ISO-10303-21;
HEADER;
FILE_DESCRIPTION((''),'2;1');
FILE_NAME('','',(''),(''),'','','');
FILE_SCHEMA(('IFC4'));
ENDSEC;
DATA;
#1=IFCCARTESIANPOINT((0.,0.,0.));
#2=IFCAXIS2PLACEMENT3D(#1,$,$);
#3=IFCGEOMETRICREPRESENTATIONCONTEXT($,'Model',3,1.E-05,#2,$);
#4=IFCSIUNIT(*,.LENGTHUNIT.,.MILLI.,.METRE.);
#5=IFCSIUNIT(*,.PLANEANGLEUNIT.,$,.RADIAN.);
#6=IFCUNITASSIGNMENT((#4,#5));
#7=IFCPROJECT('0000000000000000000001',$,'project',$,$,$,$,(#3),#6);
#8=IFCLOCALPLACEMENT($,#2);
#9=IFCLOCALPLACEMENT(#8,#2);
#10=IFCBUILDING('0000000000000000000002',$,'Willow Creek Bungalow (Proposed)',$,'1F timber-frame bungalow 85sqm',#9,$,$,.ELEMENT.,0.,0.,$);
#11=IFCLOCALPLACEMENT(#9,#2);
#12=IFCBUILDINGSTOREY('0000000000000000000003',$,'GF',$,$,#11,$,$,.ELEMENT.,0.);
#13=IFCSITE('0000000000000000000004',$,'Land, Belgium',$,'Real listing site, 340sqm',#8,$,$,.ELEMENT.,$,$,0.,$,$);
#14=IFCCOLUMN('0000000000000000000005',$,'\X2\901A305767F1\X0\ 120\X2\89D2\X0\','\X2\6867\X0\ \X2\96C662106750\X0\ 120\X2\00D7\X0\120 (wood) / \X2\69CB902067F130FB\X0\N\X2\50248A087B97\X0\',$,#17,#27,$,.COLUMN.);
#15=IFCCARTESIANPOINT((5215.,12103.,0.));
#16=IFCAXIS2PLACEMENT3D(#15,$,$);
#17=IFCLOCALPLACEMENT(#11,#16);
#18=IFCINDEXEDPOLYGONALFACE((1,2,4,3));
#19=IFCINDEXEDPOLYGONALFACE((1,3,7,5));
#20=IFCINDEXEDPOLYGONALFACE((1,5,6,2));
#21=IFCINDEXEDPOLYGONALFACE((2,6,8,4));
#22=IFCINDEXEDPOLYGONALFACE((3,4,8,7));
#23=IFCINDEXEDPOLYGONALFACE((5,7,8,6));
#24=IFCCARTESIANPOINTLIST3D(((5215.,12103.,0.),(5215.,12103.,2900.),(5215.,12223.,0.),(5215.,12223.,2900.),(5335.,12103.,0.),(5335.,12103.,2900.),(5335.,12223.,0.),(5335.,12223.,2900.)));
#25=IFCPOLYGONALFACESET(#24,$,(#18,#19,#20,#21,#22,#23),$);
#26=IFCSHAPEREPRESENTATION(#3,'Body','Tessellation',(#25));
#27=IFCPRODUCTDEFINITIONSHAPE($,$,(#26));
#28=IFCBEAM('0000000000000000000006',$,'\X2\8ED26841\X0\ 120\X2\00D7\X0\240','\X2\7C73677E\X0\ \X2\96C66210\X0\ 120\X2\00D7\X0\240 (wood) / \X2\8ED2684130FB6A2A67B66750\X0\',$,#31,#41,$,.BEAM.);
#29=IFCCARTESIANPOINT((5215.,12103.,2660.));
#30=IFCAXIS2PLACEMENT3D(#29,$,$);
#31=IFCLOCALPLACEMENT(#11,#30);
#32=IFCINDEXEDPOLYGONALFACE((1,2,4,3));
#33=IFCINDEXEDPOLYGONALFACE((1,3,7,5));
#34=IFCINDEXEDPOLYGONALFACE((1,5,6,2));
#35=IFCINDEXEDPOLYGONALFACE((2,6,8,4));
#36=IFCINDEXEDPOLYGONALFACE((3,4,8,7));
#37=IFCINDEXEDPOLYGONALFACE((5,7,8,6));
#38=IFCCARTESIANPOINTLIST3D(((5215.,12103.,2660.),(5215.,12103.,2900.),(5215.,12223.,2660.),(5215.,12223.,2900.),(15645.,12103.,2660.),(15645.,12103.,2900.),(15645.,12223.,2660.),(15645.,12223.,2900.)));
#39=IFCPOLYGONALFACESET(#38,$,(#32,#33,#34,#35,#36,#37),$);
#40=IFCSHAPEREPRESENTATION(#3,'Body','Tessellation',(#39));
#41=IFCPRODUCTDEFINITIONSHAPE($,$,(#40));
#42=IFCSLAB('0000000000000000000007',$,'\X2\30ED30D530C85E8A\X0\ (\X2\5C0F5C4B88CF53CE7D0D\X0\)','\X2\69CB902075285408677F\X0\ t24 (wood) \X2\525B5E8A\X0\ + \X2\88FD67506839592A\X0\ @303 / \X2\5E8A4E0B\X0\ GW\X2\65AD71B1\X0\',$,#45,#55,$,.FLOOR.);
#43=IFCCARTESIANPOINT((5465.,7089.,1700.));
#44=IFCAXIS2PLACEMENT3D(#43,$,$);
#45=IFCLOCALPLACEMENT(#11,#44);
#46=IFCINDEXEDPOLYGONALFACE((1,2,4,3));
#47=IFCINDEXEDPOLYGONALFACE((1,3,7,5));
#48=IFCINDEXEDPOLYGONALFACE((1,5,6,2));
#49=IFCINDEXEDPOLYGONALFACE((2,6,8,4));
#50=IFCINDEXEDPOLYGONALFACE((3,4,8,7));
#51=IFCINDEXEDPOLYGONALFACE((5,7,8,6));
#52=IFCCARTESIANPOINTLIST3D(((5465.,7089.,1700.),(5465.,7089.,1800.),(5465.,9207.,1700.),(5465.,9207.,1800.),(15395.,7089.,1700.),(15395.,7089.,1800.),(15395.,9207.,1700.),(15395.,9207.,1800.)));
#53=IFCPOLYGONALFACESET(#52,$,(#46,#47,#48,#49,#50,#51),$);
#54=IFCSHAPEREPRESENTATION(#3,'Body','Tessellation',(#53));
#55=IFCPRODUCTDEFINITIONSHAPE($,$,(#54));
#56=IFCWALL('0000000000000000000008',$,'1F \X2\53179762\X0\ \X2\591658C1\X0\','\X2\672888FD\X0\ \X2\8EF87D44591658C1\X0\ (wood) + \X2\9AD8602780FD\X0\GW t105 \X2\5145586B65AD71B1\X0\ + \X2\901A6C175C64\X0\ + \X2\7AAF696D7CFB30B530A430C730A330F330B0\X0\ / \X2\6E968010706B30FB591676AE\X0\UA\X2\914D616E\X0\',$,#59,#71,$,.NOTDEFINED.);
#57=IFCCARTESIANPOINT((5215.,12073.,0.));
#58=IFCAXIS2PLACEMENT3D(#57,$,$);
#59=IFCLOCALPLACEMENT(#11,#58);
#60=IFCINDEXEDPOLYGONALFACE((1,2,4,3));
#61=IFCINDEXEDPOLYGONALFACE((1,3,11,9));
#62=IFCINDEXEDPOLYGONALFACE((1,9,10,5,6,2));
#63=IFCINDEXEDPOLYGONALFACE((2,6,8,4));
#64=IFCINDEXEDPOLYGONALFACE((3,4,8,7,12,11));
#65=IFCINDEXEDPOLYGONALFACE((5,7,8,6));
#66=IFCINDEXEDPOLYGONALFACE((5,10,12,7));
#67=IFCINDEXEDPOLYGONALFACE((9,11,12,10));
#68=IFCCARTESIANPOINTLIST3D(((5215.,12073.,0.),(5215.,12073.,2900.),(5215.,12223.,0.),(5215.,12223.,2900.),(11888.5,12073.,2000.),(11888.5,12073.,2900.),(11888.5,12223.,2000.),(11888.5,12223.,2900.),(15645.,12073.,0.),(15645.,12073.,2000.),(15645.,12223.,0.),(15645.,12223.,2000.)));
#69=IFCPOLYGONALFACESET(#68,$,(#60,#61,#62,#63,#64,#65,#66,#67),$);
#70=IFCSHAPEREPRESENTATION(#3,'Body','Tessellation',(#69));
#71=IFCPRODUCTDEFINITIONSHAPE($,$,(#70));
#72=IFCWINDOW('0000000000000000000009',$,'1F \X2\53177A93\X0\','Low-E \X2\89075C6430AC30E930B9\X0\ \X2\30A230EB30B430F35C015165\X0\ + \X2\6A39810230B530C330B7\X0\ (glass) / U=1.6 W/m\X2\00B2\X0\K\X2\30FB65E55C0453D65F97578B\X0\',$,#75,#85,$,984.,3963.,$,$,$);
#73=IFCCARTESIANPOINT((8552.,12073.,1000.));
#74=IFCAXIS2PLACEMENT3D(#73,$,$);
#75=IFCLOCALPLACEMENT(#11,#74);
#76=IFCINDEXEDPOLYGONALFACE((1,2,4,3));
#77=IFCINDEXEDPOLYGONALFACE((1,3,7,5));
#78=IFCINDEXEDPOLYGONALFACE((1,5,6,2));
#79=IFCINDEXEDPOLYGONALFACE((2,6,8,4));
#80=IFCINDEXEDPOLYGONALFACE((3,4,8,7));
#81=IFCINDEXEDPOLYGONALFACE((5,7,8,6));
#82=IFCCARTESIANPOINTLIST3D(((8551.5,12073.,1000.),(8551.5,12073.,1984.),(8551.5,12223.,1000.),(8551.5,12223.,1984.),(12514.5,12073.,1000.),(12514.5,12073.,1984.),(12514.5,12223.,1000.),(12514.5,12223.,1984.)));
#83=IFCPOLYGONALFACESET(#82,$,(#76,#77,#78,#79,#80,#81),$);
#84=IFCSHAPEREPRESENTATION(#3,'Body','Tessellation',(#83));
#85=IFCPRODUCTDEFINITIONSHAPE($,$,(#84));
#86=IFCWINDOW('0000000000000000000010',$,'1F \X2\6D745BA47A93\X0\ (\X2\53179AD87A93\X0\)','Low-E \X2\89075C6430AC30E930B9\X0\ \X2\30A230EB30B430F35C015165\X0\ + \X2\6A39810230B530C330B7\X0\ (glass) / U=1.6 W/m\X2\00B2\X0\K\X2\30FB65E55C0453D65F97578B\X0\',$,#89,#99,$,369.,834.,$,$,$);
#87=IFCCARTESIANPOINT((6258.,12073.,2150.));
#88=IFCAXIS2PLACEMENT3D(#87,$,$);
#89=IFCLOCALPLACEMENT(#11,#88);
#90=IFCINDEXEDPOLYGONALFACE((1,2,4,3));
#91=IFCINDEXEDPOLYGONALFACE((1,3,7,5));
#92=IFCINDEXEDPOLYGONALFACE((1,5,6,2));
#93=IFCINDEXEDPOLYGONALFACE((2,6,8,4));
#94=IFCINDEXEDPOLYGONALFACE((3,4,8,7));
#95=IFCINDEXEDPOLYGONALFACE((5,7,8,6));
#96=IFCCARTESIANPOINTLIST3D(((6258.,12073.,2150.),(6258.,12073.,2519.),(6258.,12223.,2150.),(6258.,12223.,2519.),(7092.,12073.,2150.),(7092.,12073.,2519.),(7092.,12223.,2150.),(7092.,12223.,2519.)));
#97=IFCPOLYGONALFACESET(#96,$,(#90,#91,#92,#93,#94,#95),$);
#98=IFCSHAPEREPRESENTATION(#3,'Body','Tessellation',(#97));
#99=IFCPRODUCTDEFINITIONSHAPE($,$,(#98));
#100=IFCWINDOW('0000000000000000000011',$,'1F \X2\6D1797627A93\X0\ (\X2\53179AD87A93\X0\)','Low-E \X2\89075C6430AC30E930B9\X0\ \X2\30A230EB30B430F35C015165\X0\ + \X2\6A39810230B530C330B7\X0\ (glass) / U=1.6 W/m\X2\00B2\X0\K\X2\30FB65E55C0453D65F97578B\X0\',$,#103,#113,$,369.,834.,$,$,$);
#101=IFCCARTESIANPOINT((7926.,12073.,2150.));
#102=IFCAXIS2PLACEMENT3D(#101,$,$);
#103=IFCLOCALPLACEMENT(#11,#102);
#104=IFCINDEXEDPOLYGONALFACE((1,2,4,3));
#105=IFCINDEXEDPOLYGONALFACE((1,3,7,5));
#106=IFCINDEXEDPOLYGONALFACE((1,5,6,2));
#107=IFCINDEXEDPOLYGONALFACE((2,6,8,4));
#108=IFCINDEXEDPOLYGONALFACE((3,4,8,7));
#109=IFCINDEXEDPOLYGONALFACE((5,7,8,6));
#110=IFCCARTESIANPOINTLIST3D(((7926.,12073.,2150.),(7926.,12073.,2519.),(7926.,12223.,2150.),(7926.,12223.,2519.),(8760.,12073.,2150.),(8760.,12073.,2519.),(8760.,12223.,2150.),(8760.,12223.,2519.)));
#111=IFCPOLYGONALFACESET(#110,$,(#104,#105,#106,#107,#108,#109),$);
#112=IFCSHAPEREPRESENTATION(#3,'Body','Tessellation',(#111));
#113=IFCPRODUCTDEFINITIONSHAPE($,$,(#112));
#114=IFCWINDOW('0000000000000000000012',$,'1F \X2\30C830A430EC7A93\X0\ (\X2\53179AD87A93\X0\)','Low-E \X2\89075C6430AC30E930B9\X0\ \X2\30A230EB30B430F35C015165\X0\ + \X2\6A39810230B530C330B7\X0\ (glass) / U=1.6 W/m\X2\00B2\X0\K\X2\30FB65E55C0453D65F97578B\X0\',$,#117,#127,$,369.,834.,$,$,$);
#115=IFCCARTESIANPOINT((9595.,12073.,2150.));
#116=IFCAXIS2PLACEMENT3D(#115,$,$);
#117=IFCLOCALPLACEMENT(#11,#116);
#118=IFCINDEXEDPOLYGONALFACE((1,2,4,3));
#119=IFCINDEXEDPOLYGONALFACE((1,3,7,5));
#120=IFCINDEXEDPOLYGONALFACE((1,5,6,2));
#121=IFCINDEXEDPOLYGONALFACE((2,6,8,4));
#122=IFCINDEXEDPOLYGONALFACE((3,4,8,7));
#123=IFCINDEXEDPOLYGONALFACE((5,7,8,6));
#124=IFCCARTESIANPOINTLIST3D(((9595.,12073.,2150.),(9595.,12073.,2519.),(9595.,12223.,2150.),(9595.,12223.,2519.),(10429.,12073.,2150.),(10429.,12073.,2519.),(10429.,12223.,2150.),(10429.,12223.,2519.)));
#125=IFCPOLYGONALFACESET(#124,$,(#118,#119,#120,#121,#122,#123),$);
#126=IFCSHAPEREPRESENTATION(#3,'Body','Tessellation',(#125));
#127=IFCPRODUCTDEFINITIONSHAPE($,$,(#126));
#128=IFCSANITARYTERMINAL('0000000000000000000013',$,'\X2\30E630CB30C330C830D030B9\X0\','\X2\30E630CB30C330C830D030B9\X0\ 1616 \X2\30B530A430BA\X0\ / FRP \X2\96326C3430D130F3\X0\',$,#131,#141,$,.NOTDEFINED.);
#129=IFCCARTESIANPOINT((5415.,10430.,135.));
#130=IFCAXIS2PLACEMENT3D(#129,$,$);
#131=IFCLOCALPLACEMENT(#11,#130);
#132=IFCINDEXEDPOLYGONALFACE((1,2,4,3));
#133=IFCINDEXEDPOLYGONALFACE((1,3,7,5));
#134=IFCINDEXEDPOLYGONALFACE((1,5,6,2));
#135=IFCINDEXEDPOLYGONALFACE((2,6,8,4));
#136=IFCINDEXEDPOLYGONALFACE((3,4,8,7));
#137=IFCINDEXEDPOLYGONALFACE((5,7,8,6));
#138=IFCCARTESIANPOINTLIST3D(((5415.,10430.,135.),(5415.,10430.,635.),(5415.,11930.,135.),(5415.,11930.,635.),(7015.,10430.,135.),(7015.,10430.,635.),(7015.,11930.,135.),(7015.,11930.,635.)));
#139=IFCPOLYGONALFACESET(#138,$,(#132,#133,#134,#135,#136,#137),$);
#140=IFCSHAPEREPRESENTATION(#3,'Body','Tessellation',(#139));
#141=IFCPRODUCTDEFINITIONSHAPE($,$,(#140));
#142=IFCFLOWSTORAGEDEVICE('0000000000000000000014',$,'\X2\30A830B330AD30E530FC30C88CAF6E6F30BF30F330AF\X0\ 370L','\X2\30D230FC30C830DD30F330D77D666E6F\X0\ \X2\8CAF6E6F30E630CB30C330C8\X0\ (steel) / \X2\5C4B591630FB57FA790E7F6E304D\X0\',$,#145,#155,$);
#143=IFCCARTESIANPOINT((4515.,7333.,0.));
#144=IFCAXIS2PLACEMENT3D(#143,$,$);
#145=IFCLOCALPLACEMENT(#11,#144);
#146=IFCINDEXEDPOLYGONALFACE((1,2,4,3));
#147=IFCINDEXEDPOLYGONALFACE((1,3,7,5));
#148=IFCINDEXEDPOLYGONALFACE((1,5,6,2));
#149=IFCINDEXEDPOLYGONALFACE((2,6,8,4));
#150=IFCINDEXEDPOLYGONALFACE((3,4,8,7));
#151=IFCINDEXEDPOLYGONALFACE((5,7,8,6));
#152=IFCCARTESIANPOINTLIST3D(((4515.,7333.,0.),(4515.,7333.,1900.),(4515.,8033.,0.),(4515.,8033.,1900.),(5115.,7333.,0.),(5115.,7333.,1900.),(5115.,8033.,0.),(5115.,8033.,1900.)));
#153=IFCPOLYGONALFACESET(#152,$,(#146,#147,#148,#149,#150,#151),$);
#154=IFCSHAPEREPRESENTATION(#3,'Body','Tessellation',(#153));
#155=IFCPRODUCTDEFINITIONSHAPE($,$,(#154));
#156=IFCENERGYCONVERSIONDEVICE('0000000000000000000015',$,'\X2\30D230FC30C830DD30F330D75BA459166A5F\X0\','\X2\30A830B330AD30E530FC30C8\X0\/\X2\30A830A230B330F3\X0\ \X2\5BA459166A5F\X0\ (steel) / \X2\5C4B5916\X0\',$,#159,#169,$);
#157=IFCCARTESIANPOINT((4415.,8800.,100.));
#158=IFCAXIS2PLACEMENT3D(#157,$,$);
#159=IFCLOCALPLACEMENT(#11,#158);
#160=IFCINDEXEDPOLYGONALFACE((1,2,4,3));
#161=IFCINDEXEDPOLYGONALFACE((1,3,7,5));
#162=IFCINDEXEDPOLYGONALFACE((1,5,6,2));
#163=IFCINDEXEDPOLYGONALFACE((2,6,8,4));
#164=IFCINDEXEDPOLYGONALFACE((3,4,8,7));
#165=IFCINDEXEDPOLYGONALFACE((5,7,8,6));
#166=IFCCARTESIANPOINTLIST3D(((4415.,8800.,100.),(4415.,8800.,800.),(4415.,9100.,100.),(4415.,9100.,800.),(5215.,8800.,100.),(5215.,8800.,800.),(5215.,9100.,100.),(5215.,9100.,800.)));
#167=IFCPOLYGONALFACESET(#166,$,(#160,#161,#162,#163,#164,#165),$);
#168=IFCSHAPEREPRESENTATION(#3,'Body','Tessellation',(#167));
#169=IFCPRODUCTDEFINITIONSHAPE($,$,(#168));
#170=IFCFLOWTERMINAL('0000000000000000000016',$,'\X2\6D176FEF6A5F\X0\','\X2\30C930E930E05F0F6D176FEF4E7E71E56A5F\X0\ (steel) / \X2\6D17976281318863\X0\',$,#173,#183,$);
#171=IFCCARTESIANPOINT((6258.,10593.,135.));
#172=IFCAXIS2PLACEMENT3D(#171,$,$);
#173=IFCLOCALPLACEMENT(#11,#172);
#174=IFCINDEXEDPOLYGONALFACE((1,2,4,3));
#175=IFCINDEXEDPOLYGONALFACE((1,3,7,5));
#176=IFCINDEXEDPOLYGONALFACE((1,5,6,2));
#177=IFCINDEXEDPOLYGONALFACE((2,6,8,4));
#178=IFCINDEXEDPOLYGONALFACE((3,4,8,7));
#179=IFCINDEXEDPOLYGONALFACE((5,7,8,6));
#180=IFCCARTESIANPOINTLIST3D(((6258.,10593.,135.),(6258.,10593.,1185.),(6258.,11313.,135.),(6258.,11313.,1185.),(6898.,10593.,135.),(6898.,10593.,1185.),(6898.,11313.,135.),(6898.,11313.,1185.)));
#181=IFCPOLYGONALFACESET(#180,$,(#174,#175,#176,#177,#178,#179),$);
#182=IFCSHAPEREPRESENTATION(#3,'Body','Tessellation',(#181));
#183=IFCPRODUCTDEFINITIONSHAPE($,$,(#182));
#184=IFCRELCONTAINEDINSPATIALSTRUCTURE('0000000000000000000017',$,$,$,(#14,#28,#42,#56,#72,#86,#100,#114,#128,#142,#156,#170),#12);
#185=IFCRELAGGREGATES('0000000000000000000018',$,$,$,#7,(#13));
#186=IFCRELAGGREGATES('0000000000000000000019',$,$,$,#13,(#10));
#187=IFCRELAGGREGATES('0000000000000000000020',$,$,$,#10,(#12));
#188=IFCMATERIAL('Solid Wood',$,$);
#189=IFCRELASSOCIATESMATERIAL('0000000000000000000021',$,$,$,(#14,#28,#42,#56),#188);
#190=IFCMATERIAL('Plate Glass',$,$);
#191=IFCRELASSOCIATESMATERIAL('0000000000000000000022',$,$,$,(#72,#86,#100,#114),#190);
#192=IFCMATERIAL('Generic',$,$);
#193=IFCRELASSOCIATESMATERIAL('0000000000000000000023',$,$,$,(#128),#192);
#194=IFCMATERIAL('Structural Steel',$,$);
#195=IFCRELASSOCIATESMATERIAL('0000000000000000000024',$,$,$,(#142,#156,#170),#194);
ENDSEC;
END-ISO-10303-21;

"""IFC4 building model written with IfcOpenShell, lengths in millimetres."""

from ifc_helpers import new_model, si_unit, frame, frame_2d, origin, place, context, project, spatial, rectangle, extrude, material, element, fill, save


model = new_model("IFC4")

# Units and contexts
model_context = context("Model", 3, precision=1e-05, world=origin())
ifc_project = project(units=[si_unit("LENGTHUNIT", "METRE", prefix="MILLI"), si_unit("PLANEANGLEUNIT", "RADIAN")], contexts=[model_context])

# Site, building, storey
site_placement = place(None, origin())
site = spatial("IfcSite", under=ifc_project, at=site_placement, Name="Land, Belgium", ObjectType="Real listing site, 340sqm", CompositionType="ELEMENT", RefElevation=0.0)
building_placement = place(site_placement, origin())
building = spatial("IfcBuilding", under=site, at=building_placement, Name="Willow Creek Bungalow (Proposed)", ObjectType="1F timber-frame bungalow 85sqm", CompositionType="ELEMENT", ElevationOfRefHeight=0.0, ElevationOfTerrain=0.0)
storey_placement = place(building_placement, origin())
storey = spatial("IfcBuildingStorey", under=building, at=storey_placement, Name="GF", CompositionType="ELEMENT", Elevation=0.0)

# Column
ifc_material_1 = material(Name="Solid Wood")
column_1_placement = place(storey_placement, frame((5215.0, 12103.0, 0.0)))
element("IfcColumn", 1, at=column_1_placement, inside=storey, material=ifc_material_1, Name="通し柱 120角", Description="桧 集成材 120×120 (wood) / 構造柱・N値計算", PredefinedType="COLUMN", context=model_context, shape_type="SweptSolid", body=[
    extrude(rectangle(XDim=120.0, YDim=120.0, at=frame_2d((60.0, 60.0))), frame((5215.0, 12103.0, 0.0)), (0.0, 0.0, 1.0), 2900.0),
])

# Beam
beam_1_placement = place(storey_placement, frame((5215.0, 12103.0, 2660.0)))
element("IfcBeam", 2, at=beam_1_placement, inside=storey, material=ifc_material_1, Name="軒桁 120×240", Description="米松 集成 120×240 (wood) / 軒桁・横架材", PredefinedType="BEAM", context=model_context, shape_type="SweptSolid", body=[
    extrude(rectangle(XDim=10430.0, YDim=120.0, at=frame_2d((5215.0, 60.0))), frame((5215.0, 12103.0, 2660.0)), (0.0, 0.0, 1.0), 240.0),
])

# Slab
slab_placement = place(storey_placement, frame((5465.0, 7089.0, 1700.0)))
element("IfcSlab", 3, at=slab_placement, inside=storey, material=ifc_material_1, Name="ロフト床 (小屋裏収納)", Description="構造用合板 t24 (wood) 剛床 + 製材根太 @303 / 床下 GW断熱", PredefinedType="FLOOR", context=model_context, shape_type="SweptSolid", body=[
    extrude(rectangle(XDim=9930.0, YDim=2118.0, at=frame_2d((4965.0, 1059.0))), frame((5465.0, 7089.0, 1700.0)), (0.0, 0.0, 1.0), 100.0),
])

# Wall, openings, windows
wall_1_placement = place(storey_placement, frame((5215.0, 12073.0, 0.0)))
wall_1 = element("IfcWall", 4, at=wall_1_placement, inside=storey, material=ifc_material_1, Name="1F 北面 外壁", Description="木製 軸組外壁 (wood) + 高性能GW t105 充填断熱 + 通気層 + 窯業系サイディング / 準耐火・外皮UA配慮", PredefinedType="NOTDEFINED", context=model_context, shape_type="SweptSolid", body=[
    extrude(rectangle(XDim=10430.0, YDim=150.0, at=frame_2d((5215.0, 75.0))), frame((5215.0, 12073.0, 0.0)), (0.0, 0.0, 1.0), 2900.0),
])
opening_1_placement = place(storey_placement, frame((8552.0, 12073.0, 1000.0)))
opening_1 = element("IfcOpeningElement", 5, at=opening_1_placement, cuts=wall_1, PredefinedType="NOTDEFINED", context=model_context, shape_type="SweptSolid", body=[
    extrude(rectangle(XDim=3963.0, YDim=150.0, at=frame_2d((1981.0, 75.0))), frame((8552.0, 12073.0, 1000.0)), (0.0, 0.0, 1.0), 984.0),
])
opening_2_placement = place(storey_placement, frame((6258.0, 12073.0, 2150.0)))
opening_2 = element("IfcOpeningElement", 6, at=opening_2_placement, cuts=wall_1, PredefinedType="NOTDEFINED", context=model_context, shape_type="SweptSolid", body=[
    extrude(rectangle(XDim=834.0, YDim=150.0, at=frame_2d((417.0, 75.0))), frame((6258.0, 12073.0, 2150.0)), (0.0, 0.0, 1.0), 369.0),
])
opening_3_placement = place(storey_placement, frame((7926.0, 12073.0, 2150.0)))
opening_3 = element("IfcOpeningElement", 7, at=opening_3_placement, cuts=wall_1, PredefinedType="NOTDEFINED", context=model_context, shape_type="SweptSolid", body=[
    extrude(rectangle(XDim=834.0, YDim=150.0, at=frame_2d((417.0, 75.0))), frame((7926.0, 12073.0, 2150.0)), (0.0, 0.0, 1.0), 369.0),
])
opening_4_placement = place(storey_placement, frame((9595.0, 12073.0, 2150.0)))
opening_4 = element("IfcOpeningElement", 8, at=opening_4_placement, cuts=wall_1, PredefinedType="NOTDEFINED", context=model_context, shape_type="SweptSolid", body=[
    extrude(rectangle(XDim=834.0, YDim=150.0, at=frame_2d((417.0, 75.0))), frame((9595.0, 12073.0, 2150.0)), (0.0, 0.0, 1.0), 369.0),
])
ifc_material_2 = material(Name="Plate Glass")
window_1_placement = place(storey_placement, frame((8552.0, 12073.0, 1000.0)))
window_1 = element("IfcWindow", 9, at=window_1_placement, inside=storey, material=ifc_material_2, Name="1F 北窓", Description="Low-E 複層ガラス アルゴン封入 + 樹脂サッシ (glass) / U=1.6 W/m²K・日射取得型", OverallHeight=984.0, OverallWidth=3963.0, context=model_context, shape_type="SweptSolid", body=[
    extrude(rectangle(XDim=3963.0, YDim=150.0, at=frame_2d((1981.0, 75.0))), frame((8552.0, 12073.0, 1000.0)), (0.0, 0.0, 1.0), 984.0),
])
fill(opening_1, window_1)
window_2_placement = place(storey_placement, frame((6258.0, 12073.0, 2150.0)))
window_2 = element("IfcWindow", 10, at=window_2_placement, inside=storey, material=ifc_material_2, Name="1F 浴室窓 (北高窓)", Description="Low-E 複層ガラス アルゴン封入 + 樹脂サッシ (glass) / U=1.6 W/m²K・日射取得型", OverallHeight=369.0, OverallWidth=834.0, context=model_context, shape_type="SweptSolid", body=[
    extrude(rectangle(XDim=834.0, YDim=150.0, at=frame_2d((417.0, 75.0))), frame((6258.0, 12073.0, 2150.0)), (0.0, 0.0, 1.0), 369.0),
])
fill(opening_2, window_2)
window_3_placement = place(storey_placement, frame((7926.0, 12073.0, 2150.0)))
window_3 = element("IfcWindow", 11, at=window_3_placement, inside=storey, material=ifc_material_2, Name="1F 洗面窓 (北高窓)", Description="Low-E 複層ガラス アルゴン封入 + 樹脂サッシ (glass) / U=1.6 W/m²K・日射取得型", OverallHeight=369.0, OverallWidth=834.0, context=model_context, shape_type="SweptSolid", body=[
    extrude(rectangle(XDim=834.0, YDim=150.0, at=frame_2d((417.0, 75.0))), frame((7926.0, 12073.0, 2150.0)), (0.0, 0.0, 1.0), 369.0),
])
fill(opening_3, window_3)
window_4_placement = place(storey_placement, frame((9595.0, 12073.0, 2150.0)))
window_4 = element("IfcWindow", 12, at=window_4_placement, inside=storey, material=ifc_material_2, Name="1F トイレ窓 (北高窓)", Description="Low-E 複層ガラス アルゴン封入 + 樹脂サッシ (glass) / U=1.6 W/m²K・日射取得型", OverallHeight=369.0, OverallWidth=834.0, context=model_context, shape_type="SweptSolid", body=[
    extrude(rectangle(XDim=834.0, YDim=150.0, at=frame_2d((417.0, 75.0))), frame((9595.0, 12073.0, 2150.0)), (0.0, 0.0, 1.0), 369.0),
])
fill(opening_4, window_4)

# Sanitary terminal
ifc_material_3 = material(Name="Generic")
sanitary_terminal_placement = place(storey_placement, frame((5415.0, 10430.0, 135.0)))
element("IfcSanitaryTerminal", 13, at=sanitary_terminal_placement, inside=storey, material=ifc_material_3, Name="ユニットバス", Description="ユニットバス 1616 サイズ / FRP 防水パン", PredefinedType="NOTDEFINED", context=model_context, shape_type="SweptSolid", body=[
    extrude(rectangle(XDim=1600.0, YDim=1500.0, at=frame_2d((800.0, 750.0))), frame((5415.0, 10430.0, 135.0)), (0.0, 0.0, 1.0), 500.0),
])

# Flow storage device
ifc_material_4 = material(Name="Structural Steel")
flow_storage_device_placement = place(storey_placement, frame((4515.0, 7333.0, 0.0)))
element("IfcFlowStorageDevice", 14, at=flow_storage_device_placement, inside=storey, material=ifc_material_4, Name="エコキュート貯湯タンク 370L", Description="ヒートポンプ給湯 貯湯ユニット (steel) / 屋外・基礎置き", context=model_context, shape_type="SweptSolid", body=[
    extrude(rectangle(XDim=600.0, YDim=700.0, at=frame_2d((300.0, 350.0))), frame((4515.0, 7333.0, 0.0)), (0.0, 0.0, 1.0), 1900.0),
])

# Energy conversion device
energy_conversion_device_placement = place(storey_placement, frame((4415.0, 8800.0, 100.0)))
element("IfcEnergyConversionDevice", 15, at=energy_conversion_device_placement, inside=storey, material=ifc_material_4, Name="ヒートポンプ室外機", Description="エコキュート/エアコン 室外機 (steel) / 屋外", context=model_context, shape_type="SweptSolid", body=[
    extrude(rectangle(XDim=800.0, YDim=300.0, at=frame_2d((400.0, 150.0))), frame((4415.0, 8800.0, 100.0)), (0.0, 0.0, 1.0), 700.0),
])

# Flow terminal
flow_terminal_placement = place(storey_placement, frame((6258.0, 10593.0, 135.0)))
element("IfcFlowTerminal", 16, at=flow_terminal_placement, inside=storey, material=ifc_material_4, Name="洗濯機", Description="ドラム式洗濯乾燥機 (steel) / 洗面脱衣", context=model_context, shape_type="SweptSolid", body=[
    extrude(rectangle(XDim=640.0, YDim=720.0, at=frame_2d((320.0, 360.0))), frame((6258.0, 10593.0, 135.0)), (0.0, 0.0, 1.0), 1050.0),
])

save(model, "model.ifc")
